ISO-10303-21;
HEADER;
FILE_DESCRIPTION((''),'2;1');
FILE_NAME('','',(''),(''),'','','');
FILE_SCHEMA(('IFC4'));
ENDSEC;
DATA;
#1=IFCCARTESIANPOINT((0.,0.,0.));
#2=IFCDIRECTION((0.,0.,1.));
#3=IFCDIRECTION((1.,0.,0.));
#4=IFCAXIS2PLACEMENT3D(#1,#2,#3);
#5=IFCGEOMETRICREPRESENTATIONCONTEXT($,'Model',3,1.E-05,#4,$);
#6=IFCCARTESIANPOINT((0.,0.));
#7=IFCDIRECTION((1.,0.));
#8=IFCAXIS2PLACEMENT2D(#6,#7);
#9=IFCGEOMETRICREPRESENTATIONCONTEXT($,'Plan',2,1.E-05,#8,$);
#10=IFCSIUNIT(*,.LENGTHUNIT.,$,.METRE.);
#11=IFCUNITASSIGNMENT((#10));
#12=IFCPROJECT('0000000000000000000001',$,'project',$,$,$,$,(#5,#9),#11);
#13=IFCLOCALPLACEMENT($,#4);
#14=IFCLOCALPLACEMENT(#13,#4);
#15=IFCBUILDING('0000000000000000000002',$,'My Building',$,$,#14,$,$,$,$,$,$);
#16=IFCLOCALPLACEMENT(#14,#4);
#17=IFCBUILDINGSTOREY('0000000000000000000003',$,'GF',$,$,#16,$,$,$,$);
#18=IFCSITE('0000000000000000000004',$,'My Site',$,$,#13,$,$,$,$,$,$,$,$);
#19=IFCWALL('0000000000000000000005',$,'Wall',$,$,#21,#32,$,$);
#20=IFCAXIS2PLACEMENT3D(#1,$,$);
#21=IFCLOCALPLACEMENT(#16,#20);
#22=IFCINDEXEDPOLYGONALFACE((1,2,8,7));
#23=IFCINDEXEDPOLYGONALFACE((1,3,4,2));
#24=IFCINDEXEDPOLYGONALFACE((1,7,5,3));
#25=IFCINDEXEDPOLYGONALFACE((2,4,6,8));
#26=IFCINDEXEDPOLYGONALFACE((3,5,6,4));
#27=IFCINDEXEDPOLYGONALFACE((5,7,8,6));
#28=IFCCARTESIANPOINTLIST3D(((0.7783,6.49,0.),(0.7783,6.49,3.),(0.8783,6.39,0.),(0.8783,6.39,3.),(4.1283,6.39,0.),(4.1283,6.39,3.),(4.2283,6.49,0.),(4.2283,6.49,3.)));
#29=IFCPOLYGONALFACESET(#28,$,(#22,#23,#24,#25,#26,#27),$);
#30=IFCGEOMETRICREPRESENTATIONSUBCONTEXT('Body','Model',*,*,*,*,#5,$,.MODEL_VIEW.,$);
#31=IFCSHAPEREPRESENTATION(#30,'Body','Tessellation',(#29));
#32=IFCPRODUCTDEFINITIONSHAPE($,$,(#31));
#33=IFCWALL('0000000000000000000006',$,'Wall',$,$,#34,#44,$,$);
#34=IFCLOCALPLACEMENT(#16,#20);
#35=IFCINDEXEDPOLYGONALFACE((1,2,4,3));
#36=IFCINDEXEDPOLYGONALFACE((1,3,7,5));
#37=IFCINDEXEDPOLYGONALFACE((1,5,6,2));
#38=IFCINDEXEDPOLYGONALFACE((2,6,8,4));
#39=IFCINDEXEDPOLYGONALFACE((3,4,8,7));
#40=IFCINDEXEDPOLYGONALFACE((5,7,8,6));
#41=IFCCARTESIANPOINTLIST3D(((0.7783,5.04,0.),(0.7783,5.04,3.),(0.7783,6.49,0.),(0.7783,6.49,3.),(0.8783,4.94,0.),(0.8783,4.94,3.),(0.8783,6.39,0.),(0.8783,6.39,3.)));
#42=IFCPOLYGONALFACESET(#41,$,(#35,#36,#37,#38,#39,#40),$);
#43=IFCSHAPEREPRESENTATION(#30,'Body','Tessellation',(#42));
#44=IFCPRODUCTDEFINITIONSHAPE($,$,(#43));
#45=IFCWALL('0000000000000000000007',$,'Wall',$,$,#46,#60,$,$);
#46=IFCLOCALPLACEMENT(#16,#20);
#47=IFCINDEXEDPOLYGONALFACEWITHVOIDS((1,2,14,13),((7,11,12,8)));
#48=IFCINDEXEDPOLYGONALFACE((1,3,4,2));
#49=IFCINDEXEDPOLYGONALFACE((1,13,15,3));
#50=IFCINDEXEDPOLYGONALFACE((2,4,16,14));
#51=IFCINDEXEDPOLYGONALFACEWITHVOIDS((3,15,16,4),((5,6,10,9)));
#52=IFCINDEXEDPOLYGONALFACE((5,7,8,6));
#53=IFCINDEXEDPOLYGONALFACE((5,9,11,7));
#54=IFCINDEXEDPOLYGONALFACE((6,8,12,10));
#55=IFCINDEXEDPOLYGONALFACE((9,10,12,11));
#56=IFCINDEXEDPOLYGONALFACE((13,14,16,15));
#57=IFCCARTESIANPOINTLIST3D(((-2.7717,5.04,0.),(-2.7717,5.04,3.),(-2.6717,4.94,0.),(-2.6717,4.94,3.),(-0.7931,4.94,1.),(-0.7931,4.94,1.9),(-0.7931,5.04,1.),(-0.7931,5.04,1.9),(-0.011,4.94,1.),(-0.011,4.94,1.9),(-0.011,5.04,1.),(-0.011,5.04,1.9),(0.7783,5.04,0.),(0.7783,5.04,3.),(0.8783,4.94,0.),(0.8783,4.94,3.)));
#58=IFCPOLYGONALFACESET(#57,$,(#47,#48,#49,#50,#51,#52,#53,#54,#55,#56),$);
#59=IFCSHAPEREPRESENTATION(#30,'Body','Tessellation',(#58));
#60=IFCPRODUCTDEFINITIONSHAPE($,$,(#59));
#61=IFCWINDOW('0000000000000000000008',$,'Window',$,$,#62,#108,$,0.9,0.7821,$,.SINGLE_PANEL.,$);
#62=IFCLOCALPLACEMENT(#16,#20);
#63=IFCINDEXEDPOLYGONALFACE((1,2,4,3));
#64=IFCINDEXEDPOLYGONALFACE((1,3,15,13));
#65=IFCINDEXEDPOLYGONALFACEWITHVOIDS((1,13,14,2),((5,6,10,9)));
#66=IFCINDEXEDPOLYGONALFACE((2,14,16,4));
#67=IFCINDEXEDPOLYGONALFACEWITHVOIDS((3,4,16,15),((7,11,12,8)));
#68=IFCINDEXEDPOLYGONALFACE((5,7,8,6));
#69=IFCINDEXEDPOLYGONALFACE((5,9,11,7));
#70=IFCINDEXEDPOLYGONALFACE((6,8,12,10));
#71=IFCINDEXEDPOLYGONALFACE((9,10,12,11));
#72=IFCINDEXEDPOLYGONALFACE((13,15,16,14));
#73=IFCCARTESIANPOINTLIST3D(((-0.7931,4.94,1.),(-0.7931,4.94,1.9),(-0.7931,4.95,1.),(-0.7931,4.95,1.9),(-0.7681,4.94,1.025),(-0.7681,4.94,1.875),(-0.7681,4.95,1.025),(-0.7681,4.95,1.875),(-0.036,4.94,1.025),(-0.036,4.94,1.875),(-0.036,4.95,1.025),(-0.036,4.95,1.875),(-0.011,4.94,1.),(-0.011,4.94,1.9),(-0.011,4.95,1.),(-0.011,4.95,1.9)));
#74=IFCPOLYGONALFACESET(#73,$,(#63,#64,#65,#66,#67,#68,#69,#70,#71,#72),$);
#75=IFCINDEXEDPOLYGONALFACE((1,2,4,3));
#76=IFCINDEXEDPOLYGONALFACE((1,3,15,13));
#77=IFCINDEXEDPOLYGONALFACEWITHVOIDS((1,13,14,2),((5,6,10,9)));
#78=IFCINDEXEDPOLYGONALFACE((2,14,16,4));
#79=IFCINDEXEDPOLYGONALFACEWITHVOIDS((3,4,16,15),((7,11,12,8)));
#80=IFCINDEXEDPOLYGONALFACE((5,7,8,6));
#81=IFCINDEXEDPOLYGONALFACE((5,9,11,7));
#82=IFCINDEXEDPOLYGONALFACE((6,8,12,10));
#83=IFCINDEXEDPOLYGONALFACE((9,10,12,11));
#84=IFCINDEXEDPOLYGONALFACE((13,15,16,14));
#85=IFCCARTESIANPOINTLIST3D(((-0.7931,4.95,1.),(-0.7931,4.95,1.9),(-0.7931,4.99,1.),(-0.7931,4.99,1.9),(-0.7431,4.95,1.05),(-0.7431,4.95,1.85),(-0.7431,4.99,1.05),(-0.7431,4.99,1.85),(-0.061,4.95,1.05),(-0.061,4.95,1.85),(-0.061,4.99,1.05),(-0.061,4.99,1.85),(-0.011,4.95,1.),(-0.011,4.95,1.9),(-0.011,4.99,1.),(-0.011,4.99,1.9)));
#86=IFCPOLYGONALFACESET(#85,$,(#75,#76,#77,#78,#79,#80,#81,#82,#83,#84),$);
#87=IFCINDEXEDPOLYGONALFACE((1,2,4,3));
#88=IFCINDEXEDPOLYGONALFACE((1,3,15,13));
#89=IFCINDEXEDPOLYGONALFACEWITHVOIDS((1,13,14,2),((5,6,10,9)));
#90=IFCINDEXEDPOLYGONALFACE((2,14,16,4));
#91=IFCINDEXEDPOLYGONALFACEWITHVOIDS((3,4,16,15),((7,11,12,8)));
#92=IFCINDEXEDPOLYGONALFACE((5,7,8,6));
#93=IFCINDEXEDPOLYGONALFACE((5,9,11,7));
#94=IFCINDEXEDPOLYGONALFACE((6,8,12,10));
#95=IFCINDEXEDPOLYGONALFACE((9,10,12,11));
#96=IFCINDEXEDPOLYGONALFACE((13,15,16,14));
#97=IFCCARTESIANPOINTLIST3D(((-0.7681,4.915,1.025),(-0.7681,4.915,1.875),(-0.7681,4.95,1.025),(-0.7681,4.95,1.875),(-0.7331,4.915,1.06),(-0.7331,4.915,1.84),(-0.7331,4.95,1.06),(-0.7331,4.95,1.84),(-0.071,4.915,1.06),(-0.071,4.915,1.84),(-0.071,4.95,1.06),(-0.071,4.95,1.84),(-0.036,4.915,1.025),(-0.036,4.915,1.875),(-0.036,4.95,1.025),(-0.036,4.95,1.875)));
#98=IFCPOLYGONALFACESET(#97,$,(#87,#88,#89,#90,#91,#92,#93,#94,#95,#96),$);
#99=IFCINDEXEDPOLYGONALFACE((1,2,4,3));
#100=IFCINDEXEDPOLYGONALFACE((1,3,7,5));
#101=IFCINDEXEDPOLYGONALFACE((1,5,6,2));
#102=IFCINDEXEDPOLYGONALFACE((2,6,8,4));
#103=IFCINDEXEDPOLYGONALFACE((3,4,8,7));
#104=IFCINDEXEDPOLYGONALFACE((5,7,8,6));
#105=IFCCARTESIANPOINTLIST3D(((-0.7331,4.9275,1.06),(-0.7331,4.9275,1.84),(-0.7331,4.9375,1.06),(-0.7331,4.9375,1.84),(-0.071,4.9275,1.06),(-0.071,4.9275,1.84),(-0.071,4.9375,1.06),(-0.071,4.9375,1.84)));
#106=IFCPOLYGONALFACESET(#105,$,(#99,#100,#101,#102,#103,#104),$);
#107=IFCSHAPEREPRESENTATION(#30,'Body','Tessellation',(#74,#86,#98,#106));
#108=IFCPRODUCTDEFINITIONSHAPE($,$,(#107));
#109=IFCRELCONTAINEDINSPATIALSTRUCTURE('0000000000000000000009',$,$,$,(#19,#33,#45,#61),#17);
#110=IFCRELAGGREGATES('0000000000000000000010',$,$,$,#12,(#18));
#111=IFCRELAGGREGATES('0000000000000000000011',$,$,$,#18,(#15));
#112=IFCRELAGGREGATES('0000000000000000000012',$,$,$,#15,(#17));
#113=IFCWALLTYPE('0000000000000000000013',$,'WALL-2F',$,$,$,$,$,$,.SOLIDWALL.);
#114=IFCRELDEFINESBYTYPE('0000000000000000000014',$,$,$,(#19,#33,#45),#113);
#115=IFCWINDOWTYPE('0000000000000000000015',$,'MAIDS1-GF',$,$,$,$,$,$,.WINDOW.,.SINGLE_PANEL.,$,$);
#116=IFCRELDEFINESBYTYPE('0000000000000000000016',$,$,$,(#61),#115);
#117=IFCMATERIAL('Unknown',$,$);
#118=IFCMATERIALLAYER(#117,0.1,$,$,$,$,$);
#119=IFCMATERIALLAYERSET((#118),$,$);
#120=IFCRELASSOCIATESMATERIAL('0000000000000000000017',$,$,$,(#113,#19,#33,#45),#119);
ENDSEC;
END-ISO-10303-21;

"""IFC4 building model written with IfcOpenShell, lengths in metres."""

from ifc_helpers import new_model, entity, si_unit, frame, origin_with_axes, origin_2d_with_axis, place, context, subcontext, project, spatial, line, indexed_curve, outline, extrude, shape, source, transform, mapped, material, layer, layer_set, layer_usage, type_object, type_shapes, element, fill, save


model = new_model("IFC4")

# Units and contexts
model_context = context("Model", 3, precision=1e-05, world=origin_with_axes())
plan_context = context("Plan", 2, precision=1e-05, world=origin_2d_with_axis())
body_context_1 = subcontext(model_context, "Body", "Model", "MODEL_VIEW")
body_context_2 = subcontext(plan_context, "Body", "Plan", "PLAN_VIEW")
ifc_project = project(units=[si_unit("LENGTHUNIT", "METRE")], contexts=[model_context, plan_context])

# Site, building, storey
site_placement = place(None, origin_with_axes())
site = spatial("IfcSite", under=ifc_project, at=site_placement, Name="My Site")
building_placement = place(site_placement, origin_with_axes())
building = spatial("IfcBuilding", under=site, at=building_placement, Name="My Building")
storey_placement = place(building_placement, origin_with_axes())
storey = spatial("IfcBuildingStorey", under=building, at=storey_placement, Name="GF")

# Walls
ifc_material = material(Name="Unknown")
ifc_layer = layer(ifc_material, 0.1)
ifc_layer_set = layer_set([ifc_layer])
ifc_layer_usage_1 = layer_usage(ifc_layer_set, "AXIS2", "POSITIVE", 0.0)
wall_type = type_object("IfcWallType", Name="WALL-2F", PredefinedType="SOLIDWALL", material=ifc_layer_set)
wall_1_placement = place(storey_placement, frame((4.2283, 6.49, 0.0), z_axis=(0.0, 0.0, 1.0), x_axis=(-1.0, 0.0, 0.0)))
element("IfcWall", 1, at=wall_1_placement, inside=storey, type_object=wall_type, material=ifc_layer_usage_1, Name="Wall", context=body_context_1, shape_type="SweptSolid", body=[
    extrude(outline(indexed_curve([(0.0, 0.0), (0.1, 0.1), (3.35, 0.1), (3.45, 0.0)], segments=[line(1, 2, 3, 4, 1)])), origin_with_axes(), (0.0, 0.0, 1.0), 3.0),
])
ifc_layer_usage_2 = layer_usage(ifc_layer_set, "AXIS2", "POSITIVE", 0.0)
wall_2_placement = place(storey_placement, frame((0.7783, 6.49, 0.0), z_axis=(0.0, 0.0, 1.0), x_axis=(0.0, -1.0, 0.0)))
element("IfcWall", 2, at=wall_2_placement, inside=storey, type_object=wall_type, material=ifc_layer_usage_2, Name="Wall", context=body_context_1, shape_type="SweptSolid", body=[
    extrude(outline(indexed_curve([(0.0, 0.0), (0.1, 0.1), (1.55, 0.1), (1.45, 0.0)], segments=[line(1, 2, 3, 4, 1)])), origin_with_axes(), (0.0, 0.0, 1.0), 3.0),
])

# Wall, opening, window
ifc_layer_usage_3 = layer_usage(ifc_layer_set, "AXIS2", "POSITIVE", 0.0)
wall_3_placement = place(storey_placement, frame((0.7783, 5.04, 0.0), z_axis=(0.0, 0.0, 1.0), x_axis=(-1.0, 0.0, 0.0)))
wall_3 = element("IfcWall", 3, at=wall_3_placement, inside=storey, type_object=wall_type, material=ifc_layer_usage_3, Name="Wall", context=body_context_1, shape_type="SweptSolid", body=[
    extrude(outline(indexed_curve([(0.0, 0.0), (-0.1, 0.1), (3.45, 0.1), (3.55, 0.0)], segments=[line(1, 2, 3, 4, 1)])), origin_with_axes(), (0.0, 0.0, 1.0), 3.0),
])
shared_shape_1 = source(origin_with_axes(), body_context_1, "Body", "SweptSolid", [
    extrude(outline(indexed_curve([(0.0, 0.0), (0.7821, 0.0), (0.7821, 0.9), (0.0, 0.9)], segments=[line(1, 2, 3, 4, 1)])), frame((0.0, -0.6, 0.0), z_axis=(0.0, -1.0, 0.0), x_axis=(1.0, 0.0, 0.0)), (0.0, 0.0, -1.0), 1.2),
])
opening_1_placement = place(wall_3_placement, frame((0.7893, 0.0, 1.0), z_axis=(0.0, 0.0, 1.0), x_axis=(1.0, 0.0, 0.0)))
opening_1 = element("IfcOpeningElement", 4, at=opening_1_placement, cuts=wall_3, PredefinedType="OPENING", context=body_context_1, shape_type="MappedRepresentation", body=[
    mapped(shared_shape_1, transform((0.0, 0.0, 0.0), x_axis=(1.0, 0.0, 0.0), y_axis=(0.0, 1.0, 0.0), z_axis=(0.0, 0.0, 1.0), scale=1.0)),
])
window_type_1 = type_object("IfcWindowType", Name="MAIDS1-GF", PartitioningType="SINGLE_PANEL", PredefinedType="WINDOW")
shared_shape_2 = source(origin_with_axes(), body_context_1, "Body", "SweptSolid", [
    extrude(outline(indexed_curve([(0.0, 0.0), (0.7821, 0.0), (0.7821, 0.9), (0.0, 0.9)], segments=[line(1, 2, 3, 4, 1)]), holes=[indexed_curve([(0.025, 0.025), (0.7571, 0.025), (0.7571, 0.875), (0.025, 0.875)], segments=[line(1, 2, 3, 4, 1)])]), frame((0.0, 0.09, 0.0), z_axis=(0.0, -1.0, 0.0), x_axis=(1.0, 0.0, 0.0)), (0.0, 0.0, -1.0), 0.01),
    extrude(outline(indexed_curve([(0.0, 0.0), (0.7821, 0.0), (0.7821, 0.9), (0.0, 0.9)], segments=[line(1, 2, 3, 4, 1)]), holes=[indexed_curve([(0.05, 0.05), (0.7321, 0.05), (0.7321, 0.85), (0.05, 0.85)], segments=[line(1, 2, 3, 4, 1)])]), frame((0.0, 0.05, 0.0), z_axis=(0.0, -1.0, 0.0), x_axis=(1.0, 0.0, 0.0)), (0.0, 0.0, -1.0), 0.04),
    extrude(outline(indexed_curve([(0.0, 0.0), (0.7321, 0.0), (0.7321, 0.85), (0.0, 0.85)], segments=[line(1, 2, 3, 4, 1)]), holes=[indexed_curve([(0.035, 0.035), (0.6971, 0.035), (0.6971, 0.815), (0.035, 0.815)], segments=[line(1, 2, 3, 4, 1)])]), frame((0.025, 0.09, 0.025), z_axis=(0.0, -1.0, 0.0), x_axis=(1.0, 0.0, 0.0)), (0.0, 0.0, -1.0), 0.035),
    extrude(outline(indexed_curve([(0.035, 0.035), (0.6971, 0.035), (0.6971, 0.815), (0.035, 0.815)], segments=[line(1, 2, 3, 4, 1)])), frame((0.025, 0.1025, 0.025), z_axis=(0.0, -1.0, 0.0), x_axis=(1.0, 0.0, 0.0)), (0.0, 0.0, -1.0), 0.01),
])
shared_shape_3 = source(origin_with_axes(), body_context_2, "Body", "Curve2D", [
    entity("IfcIndexedPolyCurve", entity("IfcCartesianPointList2D", [[0.05, 0.05], [0.7321, 0.05]])),
    entity("IfcIndexedPolyCurve", entity("IfcCartesianPointList2D", [[0.0, 0.1], [0.025, 0.1], [0.025, 0.09], [0.05, 0.09], [0.05, 0.05], [0.0, 0.05]]), [entity("IfcLineIndex", [1, 2, 3, 4, 5, 6, 1])]),
    entity("IfcIndexedPolyCurve", entity("IfcCartesianPointList2D", [[0.7821, 0.1], [0.7571, 0.1], [0.7571, 0.09], [0.7321, 0.09], [0.7321, 0.05], [0.7821, 0.05]]), [entity("IfcLineIndex", [1, 2, 3, 4, 5, 6, 1])]),
    entity("IfcIndexedPolyCurve", entity("IfcCartesianPointList2D", [[0.025, 0.09], [0.06, 0.09], [0.06, 0.125], [0.025, 0.125]]), [entity("IfcLineIndex", [1, 2, 3, 4, 1])]),
    entity("IfcIndexedPolyCurve", entity("IfcCartesianPointList2D", [[0.7571, 0.09], [0.7221, 0.09], [0.7221, 0.125], [0.7571, 0.125]]), [entity("IfcLineIndex", [1, 2, 3, 4, 1])]),
    entity("IfcIndexedPolyCurve", entity("IfcCartesianPointList2D", [[0.06, 0.09], [0.7221, 0.09]])),
    entity("IfcIndexedPolyCurve", entity("IfcCartesianPointList2D", [[0.06, 0.125], [0.7221, 0.125]])),
    entity("IfcIndexedPolyCurve", entity("IfcCartesianPointList2D", [[0.06, 0.1075], [0.7221, 0.1075]])),
])
type_shapes(window_type_1, [shared_shape_2, shared_shape_3])
window_1_placement = place(opening_1_placement, frame((0.0, 0.0, 0.0), z_axis=(0.0, 0.0, 1.0), x_axis=(1.0, 0.0, 0.0)))
window_1 = element("IfcWindow", 5, at=window_1_placement, inside=storey, type_object=window_type_1, Name="Window", OverallHeight=0.9, OverallWidth=0.7821, PartitioningType="SINGLE_PANEL", shapes=[
    shape(body_context_1, "Body", "MappedRepresentation", [mapped(shared_shape_2, transform((0.0, 0.0, 0.0), x_axis=(1.0, 0.0, 0.0), y_axis=(0.0, 1.0, 0.0), z_axis=(0.0, 0.0, 1.0), scale=1.0))]),
    shape(body_context_2, "Body", "MappedRepresentation", [mapped(shared_shape_3, transform((0.0, 0.0, 0.0), x_axis=(1.0, 0.0, 0.0), y_axis=(0.0, 1.0, 0.0), z_axis=(0.0, 0.0, 1.0), scale=1.0))]),
])
fill(opening_1, window_1)

save(model, "model.ifc")
